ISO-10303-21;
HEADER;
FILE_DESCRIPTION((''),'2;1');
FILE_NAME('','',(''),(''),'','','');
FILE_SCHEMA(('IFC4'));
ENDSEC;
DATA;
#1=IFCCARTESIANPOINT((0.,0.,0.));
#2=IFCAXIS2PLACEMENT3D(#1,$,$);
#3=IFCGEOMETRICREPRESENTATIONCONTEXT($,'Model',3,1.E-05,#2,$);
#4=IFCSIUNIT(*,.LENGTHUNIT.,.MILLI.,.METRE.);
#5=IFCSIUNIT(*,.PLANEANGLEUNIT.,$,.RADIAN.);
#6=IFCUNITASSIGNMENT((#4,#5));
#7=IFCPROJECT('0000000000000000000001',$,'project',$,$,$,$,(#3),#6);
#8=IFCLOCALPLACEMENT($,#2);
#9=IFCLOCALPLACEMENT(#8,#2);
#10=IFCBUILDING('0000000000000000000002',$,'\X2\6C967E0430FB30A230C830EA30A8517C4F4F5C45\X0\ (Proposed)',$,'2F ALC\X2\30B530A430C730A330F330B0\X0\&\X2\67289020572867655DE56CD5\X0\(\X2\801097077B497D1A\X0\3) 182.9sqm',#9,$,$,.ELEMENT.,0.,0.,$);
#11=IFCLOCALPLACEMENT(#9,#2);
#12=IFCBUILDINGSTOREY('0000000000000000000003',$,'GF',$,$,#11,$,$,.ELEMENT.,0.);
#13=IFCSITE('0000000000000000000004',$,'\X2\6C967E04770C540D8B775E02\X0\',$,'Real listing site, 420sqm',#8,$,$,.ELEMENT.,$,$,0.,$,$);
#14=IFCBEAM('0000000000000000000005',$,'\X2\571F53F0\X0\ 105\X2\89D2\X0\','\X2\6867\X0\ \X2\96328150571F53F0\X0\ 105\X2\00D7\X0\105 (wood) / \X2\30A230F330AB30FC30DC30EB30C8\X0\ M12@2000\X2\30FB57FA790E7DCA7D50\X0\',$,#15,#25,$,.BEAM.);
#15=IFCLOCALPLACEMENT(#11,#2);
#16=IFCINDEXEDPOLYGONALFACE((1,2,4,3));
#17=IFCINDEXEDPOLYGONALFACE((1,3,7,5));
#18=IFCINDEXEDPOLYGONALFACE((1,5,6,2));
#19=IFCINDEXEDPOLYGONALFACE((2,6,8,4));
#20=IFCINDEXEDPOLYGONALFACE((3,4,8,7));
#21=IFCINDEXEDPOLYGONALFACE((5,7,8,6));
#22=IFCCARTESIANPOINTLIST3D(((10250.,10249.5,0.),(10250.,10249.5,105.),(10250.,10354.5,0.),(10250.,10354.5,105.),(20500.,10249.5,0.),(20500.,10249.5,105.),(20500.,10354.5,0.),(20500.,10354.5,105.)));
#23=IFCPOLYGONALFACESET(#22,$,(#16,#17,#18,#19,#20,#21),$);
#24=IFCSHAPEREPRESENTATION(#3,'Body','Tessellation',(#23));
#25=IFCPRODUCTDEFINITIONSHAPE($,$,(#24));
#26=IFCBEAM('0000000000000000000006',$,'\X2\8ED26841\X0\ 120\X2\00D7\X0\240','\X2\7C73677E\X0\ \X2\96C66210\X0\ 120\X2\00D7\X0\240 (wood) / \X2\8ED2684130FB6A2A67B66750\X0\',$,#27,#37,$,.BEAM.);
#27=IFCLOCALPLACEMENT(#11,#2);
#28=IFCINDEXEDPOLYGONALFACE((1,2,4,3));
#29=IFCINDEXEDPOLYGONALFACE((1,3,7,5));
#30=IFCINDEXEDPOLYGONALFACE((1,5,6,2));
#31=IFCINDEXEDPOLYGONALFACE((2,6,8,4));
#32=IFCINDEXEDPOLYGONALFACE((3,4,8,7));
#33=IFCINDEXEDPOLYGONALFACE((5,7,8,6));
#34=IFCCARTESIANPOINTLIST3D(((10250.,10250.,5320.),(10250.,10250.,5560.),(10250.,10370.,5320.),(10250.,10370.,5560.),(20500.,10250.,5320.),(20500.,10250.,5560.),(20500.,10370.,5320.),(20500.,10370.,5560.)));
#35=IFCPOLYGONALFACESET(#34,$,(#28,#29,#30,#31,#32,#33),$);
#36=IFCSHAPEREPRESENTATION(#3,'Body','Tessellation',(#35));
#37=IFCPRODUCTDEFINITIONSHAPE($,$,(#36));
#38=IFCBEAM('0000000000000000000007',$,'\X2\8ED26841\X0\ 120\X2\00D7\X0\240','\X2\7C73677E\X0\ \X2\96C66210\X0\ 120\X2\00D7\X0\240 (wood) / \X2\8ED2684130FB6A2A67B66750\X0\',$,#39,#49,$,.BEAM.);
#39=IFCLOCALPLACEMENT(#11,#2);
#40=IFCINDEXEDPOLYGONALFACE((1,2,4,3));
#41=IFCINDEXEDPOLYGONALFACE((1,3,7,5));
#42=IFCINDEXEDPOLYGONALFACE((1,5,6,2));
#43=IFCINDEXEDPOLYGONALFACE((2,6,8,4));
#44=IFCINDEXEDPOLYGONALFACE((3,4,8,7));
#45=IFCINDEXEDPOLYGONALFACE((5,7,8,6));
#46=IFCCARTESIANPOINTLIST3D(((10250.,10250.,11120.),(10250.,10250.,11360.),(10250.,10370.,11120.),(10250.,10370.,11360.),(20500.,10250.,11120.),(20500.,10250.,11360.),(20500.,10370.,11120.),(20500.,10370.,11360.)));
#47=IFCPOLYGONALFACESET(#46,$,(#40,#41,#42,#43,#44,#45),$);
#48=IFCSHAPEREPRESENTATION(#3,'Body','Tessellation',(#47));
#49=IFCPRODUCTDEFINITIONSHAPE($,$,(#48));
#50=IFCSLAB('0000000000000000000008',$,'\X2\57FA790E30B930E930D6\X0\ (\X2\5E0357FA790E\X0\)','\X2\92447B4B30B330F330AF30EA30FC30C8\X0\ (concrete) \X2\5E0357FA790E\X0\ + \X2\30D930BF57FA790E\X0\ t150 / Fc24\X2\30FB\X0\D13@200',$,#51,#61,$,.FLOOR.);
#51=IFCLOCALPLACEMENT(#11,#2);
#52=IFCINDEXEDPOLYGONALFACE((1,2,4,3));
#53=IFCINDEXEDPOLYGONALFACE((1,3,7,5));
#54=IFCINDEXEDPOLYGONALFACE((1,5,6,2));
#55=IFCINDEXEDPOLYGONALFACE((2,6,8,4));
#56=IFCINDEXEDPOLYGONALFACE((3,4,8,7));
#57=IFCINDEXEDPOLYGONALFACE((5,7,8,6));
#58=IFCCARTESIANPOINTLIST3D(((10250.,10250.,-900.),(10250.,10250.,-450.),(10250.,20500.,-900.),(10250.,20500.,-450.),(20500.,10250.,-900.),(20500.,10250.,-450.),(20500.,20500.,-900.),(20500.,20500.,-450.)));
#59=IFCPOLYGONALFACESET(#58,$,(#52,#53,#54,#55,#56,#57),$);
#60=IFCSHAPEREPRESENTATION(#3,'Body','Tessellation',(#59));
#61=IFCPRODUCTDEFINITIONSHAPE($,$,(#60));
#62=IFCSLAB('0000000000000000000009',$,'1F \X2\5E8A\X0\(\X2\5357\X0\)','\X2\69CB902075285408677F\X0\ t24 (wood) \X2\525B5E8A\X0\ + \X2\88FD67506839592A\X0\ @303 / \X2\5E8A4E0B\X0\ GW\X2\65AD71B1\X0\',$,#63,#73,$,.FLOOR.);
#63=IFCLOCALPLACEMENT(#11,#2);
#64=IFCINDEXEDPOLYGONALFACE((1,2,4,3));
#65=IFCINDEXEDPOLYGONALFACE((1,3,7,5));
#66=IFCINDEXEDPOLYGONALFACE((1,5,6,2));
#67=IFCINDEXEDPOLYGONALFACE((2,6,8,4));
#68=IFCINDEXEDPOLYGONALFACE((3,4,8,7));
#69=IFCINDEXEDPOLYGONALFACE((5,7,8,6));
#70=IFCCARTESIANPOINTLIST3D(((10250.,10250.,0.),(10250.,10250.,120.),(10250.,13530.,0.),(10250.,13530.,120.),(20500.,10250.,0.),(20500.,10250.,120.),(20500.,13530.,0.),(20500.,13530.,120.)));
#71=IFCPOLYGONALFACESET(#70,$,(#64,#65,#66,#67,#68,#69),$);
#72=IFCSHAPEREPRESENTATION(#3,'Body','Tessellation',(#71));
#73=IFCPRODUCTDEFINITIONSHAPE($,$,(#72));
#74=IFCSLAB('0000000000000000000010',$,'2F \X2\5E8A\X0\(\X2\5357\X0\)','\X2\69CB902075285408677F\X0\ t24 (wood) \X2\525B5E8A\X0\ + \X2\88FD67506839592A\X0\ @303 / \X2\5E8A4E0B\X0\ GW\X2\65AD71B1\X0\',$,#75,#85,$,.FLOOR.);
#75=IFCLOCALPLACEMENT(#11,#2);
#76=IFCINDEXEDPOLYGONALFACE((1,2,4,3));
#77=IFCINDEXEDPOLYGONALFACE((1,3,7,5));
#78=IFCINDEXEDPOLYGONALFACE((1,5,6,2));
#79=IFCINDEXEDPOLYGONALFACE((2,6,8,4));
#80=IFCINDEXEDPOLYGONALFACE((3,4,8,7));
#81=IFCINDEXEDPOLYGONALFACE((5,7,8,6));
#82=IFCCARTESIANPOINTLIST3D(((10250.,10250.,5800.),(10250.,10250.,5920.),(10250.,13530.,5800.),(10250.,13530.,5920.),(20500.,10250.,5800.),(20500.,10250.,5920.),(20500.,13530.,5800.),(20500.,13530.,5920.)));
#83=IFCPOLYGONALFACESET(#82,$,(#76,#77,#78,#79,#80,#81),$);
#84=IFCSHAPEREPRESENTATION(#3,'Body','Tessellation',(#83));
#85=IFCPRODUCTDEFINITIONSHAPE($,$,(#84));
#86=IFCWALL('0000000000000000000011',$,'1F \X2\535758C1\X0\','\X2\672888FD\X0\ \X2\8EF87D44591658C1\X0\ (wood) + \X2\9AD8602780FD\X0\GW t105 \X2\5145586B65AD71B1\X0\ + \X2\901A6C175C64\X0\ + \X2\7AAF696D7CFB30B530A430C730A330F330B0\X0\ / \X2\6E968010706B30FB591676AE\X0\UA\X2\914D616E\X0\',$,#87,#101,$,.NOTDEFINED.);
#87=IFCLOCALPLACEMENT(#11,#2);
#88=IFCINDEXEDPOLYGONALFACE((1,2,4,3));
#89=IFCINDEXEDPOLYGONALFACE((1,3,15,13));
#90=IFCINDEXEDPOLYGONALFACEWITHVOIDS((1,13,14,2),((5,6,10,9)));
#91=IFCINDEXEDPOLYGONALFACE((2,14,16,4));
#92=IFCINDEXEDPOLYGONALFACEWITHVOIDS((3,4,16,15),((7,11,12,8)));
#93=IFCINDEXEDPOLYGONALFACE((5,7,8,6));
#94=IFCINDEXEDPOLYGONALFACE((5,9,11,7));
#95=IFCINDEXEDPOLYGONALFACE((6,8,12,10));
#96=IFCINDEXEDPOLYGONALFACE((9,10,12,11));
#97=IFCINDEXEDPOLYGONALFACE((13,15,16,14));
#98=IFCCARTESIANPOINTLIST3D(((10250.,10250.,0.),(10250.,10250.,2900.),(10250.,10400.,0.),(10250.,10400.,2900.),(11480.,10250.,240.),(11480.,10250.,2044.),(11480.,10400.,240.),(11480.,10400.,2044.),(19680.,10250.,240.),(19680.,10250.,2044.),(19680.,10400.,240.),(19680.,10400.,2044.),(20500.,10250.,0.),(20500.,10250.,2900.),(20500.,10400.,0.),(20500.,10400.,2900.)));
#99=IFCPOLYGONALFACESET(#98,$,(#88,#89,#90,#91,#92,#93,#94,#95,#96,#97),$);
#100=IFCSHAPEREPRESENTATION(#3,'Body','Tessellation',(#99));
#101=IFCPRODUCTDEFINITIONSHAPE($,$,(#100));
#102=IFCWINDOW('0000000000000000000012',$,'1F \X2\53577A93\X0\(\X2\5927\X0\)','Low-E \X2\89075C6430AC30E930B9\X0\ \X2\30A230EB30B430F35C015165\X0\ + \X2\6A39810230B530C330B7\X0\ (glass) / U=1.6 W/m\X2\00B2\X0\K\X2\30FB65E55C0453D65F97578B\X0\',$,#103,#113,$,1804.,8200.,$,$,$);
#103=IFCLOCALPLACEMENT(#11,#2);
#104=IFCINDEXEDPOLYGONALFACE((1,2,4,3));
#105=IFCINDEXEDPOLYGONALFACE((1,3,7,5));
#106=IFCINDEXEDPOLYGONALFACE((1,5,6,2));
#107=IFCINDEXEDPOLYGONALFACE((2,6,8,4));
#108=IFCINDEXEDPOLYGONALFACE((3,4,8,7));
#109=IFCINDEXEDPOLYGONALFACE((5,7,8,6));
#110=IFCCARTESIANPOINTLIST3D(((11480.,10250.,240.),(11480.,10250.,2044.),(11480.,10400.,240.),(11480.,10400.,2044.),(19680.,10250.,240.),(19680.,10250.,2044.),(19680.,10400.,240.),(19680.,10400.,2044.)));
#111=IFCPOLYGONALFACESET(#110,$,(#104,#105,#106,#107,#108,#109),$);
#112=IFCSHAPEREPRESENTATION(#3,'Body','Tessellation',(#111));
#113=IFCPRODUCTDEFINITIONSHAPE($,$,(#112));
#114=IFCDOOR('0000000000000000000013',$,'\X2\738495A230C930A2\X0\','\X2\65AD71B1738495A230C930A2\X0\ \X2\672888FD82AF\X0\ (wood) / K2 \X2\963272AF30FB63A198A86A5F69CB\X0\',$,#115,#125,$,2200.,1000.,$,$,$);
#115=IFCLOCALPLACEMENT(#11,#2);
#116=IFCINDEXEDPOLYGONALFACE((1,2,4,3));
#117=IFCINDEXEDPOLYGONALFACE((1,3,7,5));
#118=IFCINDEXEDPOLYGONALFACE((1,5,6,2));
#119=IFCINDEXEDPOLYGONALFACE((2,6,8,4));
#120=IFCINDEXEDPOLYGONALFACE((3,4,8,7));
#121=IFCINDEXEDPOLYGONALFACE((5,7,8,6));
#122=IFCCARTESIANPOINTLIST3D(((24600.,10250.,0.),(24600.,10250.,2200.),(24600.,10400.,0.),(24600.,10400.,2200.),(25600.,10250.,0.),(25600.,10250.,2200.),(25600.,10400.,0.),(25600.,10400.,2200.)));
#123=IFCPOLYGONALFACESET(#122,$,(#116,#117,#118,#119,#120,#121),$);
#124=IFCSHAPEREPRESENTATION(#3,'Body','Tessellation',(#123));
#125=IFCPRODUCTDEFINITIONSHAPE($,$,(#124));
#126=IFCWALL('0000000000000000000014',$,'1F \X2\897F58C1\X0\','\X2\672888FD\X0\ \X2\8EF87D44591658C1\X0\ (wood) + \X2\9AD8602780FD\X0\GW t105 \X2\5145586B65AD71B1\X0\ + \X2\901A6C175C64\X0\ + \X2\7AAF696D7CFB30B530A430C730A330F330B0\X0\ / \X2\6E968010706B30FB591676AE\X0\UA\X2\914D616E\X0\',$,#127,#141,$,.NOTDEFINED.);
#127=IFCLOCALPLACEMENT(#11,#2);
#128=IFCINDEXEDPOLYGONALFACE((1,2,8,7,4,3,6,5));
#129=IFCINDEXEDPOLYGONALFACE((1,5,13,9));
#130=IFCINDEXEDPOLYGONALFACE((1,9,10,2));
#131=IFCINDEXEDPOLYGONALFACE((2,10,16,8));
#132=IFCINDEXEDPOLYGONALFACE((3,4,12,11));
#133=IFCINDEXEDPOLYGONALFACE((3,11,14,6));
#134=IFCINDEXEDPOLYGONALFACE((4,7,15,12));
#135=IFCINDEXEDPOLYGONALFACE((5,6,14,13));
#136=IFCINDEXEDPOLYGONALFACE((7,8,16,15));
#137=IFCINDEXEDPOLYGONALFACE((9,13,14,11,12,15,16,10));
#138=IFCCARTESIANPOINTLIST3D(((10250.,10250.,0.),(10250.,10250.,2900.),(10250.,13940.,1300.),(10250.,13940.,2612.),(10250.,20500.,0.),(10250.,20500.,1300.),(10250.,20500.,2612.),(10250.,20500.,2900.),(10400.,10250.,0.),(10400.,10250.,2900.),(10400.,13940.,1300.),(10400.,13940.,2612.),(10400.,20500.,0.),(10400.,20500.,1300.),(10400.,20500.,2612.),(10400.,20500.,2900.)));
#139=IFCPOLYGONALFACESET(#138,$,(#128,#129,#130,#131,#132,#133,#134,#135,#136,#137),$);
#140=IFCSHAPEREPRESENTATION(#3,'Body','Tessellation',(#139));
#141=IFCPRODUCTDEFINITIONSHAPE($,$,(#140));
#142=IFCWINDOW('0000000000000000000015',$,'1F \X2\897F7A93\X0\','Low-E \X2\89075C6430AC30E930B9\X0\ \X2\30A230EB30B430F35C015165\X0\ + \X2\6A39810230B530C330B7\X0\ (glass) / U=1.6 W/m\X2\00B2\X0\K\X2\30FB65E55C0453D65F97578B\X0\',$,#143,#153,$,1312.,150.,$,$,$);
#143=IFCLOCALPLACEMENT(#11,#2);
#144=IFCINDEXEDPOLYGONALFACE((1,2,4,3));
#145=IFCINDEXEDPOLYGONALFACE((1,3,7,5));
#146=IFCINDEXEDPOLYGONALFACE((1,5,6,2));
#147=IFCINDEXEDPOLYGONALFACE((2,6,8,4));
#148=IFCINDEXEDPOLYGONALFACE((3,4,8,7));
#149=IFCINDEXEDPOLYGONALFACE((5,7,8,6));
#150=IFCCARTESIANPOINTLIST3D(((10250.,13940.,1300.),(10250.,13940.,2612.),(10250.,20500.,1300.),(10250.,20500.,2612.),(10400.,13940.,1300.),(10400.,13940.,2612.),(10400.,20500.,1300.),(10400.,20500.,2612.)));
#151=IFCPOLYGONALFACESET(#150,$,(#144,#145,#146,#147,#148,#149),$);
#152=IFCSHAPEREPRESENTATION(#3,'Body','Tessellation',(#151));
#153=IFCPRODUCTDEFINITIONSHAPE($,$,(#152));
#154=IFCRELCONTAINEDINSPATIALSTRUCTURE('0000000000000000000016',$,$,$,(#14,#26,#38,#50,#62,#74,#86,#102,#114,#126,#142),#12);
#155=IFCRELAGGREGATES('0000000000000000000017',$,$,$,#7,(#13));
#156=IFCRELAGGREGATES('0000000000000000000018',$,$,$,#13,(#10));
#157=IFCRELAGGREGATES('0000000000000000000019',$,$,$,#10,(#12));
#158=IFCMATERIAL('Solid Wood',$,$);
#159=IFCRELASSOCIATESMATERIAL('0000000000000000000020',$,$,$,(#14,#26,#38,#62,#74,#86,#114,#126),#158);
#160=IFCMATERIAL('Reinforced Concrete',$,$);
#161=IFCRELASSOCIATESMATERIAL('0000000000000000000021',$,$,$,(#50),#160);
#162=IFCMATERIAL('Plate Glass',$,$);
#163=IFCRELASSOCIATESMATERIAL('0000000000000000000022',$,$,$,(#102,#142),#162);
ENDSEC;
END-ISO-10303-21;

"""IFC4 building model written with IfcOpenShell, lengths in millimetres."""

from ifc_helpers import new_model, si_unit, frame, frame_2d, origin, place, context, project, spatial, rectangle, extrude, material, element, fill, save


model = new_model("IFC4")

# Units and contexts
model_context = context("Model", 3, precision=1e-05, world=origin())
ifc_project = project(units=[si_unit("LENGTHUNIT", "METRE", prefix="MILLI"), si_unit("PLANEANGLEUNIT", "RADIAN")], contexts=[model_context])

# Site, building, storey
site_placement = place(None, origin())
site = spatial("IfcSite", under=ifc_project, at=site_placement, Name="沖縄県名護市", ObjectType="Real listing site, 420sqm", CompositionType="ELEMENT", RefElevation=0.0)
building_placement = place(site_placement, origin())
building = spatial("IfcBuilding", under=site, at=building_placement, Name="沖縄・アトリエ兼住居 (Proposed)", ObjectType="2F ALCサイディング&木造在来工法(耐震等級3) 182.9sqm", CompositionType="ELEMENT", ElevationOfRefHeight=0.0, ElevationOfTerrain=0.0)
storey_placement = place(building_placement, origin())
storey = spatial("IfcBuildingStorey", under=building, at=storey_placement, Name="GF", CompositionType="ELEMENT", Elevation=0.0)

# Shared definitions
ifc_material_1 = material(Name="Solid Wood")

# Beams
beam_1_placement = place(storey_placement, frame((5125.0, 5125.0, 0.0)))
element("IfcBeam", 1, at=beam_1_placement, inside=storey, material=ifc_material_1, Name="土台 105角", Description="桧 防腐土台 105×105 (wood) / アンカーボルト M12@2000・基礎緊結", PredefinedType="BEAM", context=model_context, shape_type="SweptSolid", body=[
    extrude(rectangle(XDim=10250.0, YDim=105.0, at=frame_2d((5125.0, 52.0))), frame((5125.0, 5125.0, 0.0)), (0.0, 0.0, 1.0), 105.0),
])
beam_2_placement = place(storey_placement, frame((5125.0, 5125.0, 2660.0)))
element("IfcBeam", 2, at=beam_2_placement, inside=storey, material=ifc_material_1, Name="軒桁 120×240", Description="米松 集成 120×240 (wood) / 軒桁・横架材", PredefinedType="BEAM", context=model_context, shape_type="SweptSolid", body=[
    extrude(rectangle(XDim=10250.0, YDim=120.0, at=frame_2d((5125.0, 60.0))), frame((5125.0, 5125.0, 2660.0)), (0.0, 0.0, 1.0), 240.0),
])
beam_3_placement = place(storey_placement, frame((5125.0, 5125.0, 5560.0)))
element("IfcBeam", 3, at=beam_3_placement, inside=storey, material=ifc_material_1, Name="軒桁 120×240", Description="米松 集成 120×240 (wood) / 軒桁・横架材", PredefinedType="BEAM", context=model_context, shape_type="SweptSolid", body=[
    extrude(rectangle(XDim=10250.0, YDim=120.0, at=frame_2d((5125.0, 60.0))), frame((5125.0, 5125.0, 5560.0)), (0.0, 0.0, 1.0), 240.0),
])

# Slabs
ifc_material_2 = material(Name="Reinforced Concrete")
slab_1_placement = place(storey_placement, frame((5125.0, 5125.0, -450.0)))
element("IfcSlab", 4, at=slab_1_placement, inside=storey, material=ifc_material_2, Name="基礎スラブ (布基礎)", Description="鉄筋コンクリート (concrete) 布基礎 + ベタ基礎 t150 / Fc24・D13@200", PredefinedType="FLOOR", context=model_context, shape_type="SweptSolid", body=[
    extrude(rectangle(XDim=10250.0, YDim=10250.0, at=frame_2d((5125.0, 5125.0))), frame((5125.0, 5125.0, -450.0)), (0.0, 0.0, 1.0), 450.0),
])
slab_2_placement = place(storey_placement, frame((5125.0, 5125.0, 0.0)))
element("IfcSlab", 5, at=slab_2_placement, inside=storey, material=ifc_material_1, Name="1F 床(南)", Description="構造用合板 t24 (wood) 剛床 + 製材根太 @303 / 床下 GW断熱", PredefinedType="FLOOR", context=model_context, shape_type="SweptSolid", body=[
    extrude(rectangle(XDim=10250.0, YDim=3280.0, at=frame_2d((5125.0, 1640.0))), frame((5125.0, 5125.0, 0.0)), (0.0, 0.0, 1.0), 120.0),
])
slab_3_placement = place(storey_placement, frame((5125.0, 5125.0, 2900.0)))
element("IfcSlab", 6, at=slab_3_placement, inside=storey, material=ifc_material_1, Name="2F 床(南)", Description="構造用合板 t24 (wood) 剛床 + 製材根太 @303 / 床下 GW断熱", PredefinedType="FLOOR", context=model_context, shape_type="SweptSolid", body=[
    extrude(rectangle(XDim=10250.0, YDim=3280.0, at=frame_2d((5125.0, 1640.0))), frame((5125.0, 5125.0, 2900.0)), (0.0, 0.0, 1.0), 120.0),
])

# Wall, openings, window, door
wall_1_placement = place(storey_placement, frame((5125.0, 5125.0, 0.0)))
wall_1 = element("IfcWall", 7, at=wall_1_placement, inside=storey, material=ifc_material_1, Name="1F 南壁", Description="木製 軸組外壁 (wood) + 高性能GW t105 充填断熱 + 通気層 + 窯業系サイディング / 準耐火・外皮UA配慮", PredefinedType="NOTDEFINED", context=model_context, shape_type="SweptSolid", body=[
    extrude(rectangle(XDim=10250.0, YDim=150.0, at=frame_2d((5125.0, 75.0))), frame((5125.0, 5125.0, 0.0)), (0.0, 0.0, 1.0), 2900.0),
])
opening_1_placement = place(storey_placement, frame((5740.0, 5125.0, 120.0)))
opening_1 = element("IfcOpeningElement", 8, at=opening_1_placement, cuts=wall_1, PredefinedType="NOTDEFINED", context=model_context, shape_type="SweptSolid", body=[
    extrude(rectangle(XDim=8200.0, YDim=150.0, at=frame_2d((4100.0, 75.0))), frame((5740.0, 5125.0, 120.0)), (0.0, 0.0, 1.0), 1804.0),
])
opening_2_placement = place(storey_placement, frame((12300.0, 5125.0, 0.0)))
opening_2 = element("IfcOpeningElement", 9, at=opening_2_placement, cuts=wall_1, PredefinedType="NOTDEFINED", context=model_context, shape_type="SweptSolid", body=[
    extrude(rectangle(XDim=1000.0, YDim=150.0, at=frame_2d((500.0, 75.0))), frame((12300.0, 5125.0, 0.0)), (0.0, 0.0, 1.0), 2200.0),
])
ifc_material_3 = material(Name="Plate Glass")
window_1_placement = place(storey_placement, frame((5740.0, 5125.0, 120.0)))
window_1 = element("IfcWindow", 10, at=window_1_placement, inside=storey, material=ifc_material_3, Name="1F 南窓(大)", Description="Low-E 複層ガラス アルゴン封入 + 樹脂サッシ (glass) / U=1.6 W/m²K・日射取得型", OverallHeight=1804.0, OverallWidth=8200.0, context=model_context, shape_type="SweptSolid", body=[
    extrude(rectangle(XDim=8200.0, YDim=150.0, at=frame_2d((4100.0, 75.0))), frame((5740.0, 5125.0, 120.0)), (0.0, 0.0, 1.0), 1804.0),
])
fill(opening_1, window_1)
door_placement = place(storey_placement, frame((12300.0, 5125.0, 0.0)))
door = element("IfcDoor", 11, at=door_placement, inside=storey, material=ifc_material_1, Name="玄関ドア", Description="断熱玄関ドア 木製芯 (wood) / K2 防犯・採風機構", OverallHeight=2200.0, OverallWidth=1000.0, context=model_context, shape_type="SweptSolid", body=[
    extrude(rectangle(XDim=1000.0, YDim=150.0, at=frame_2d((500.0, 75.0))), frame((12300.0, 5125.0, 0.0)), (0.0, 0.0, 1.0), 2200.0),
])
fill(opening_2, door)

# Wall, opening, window
wall_2_placement = place(storey_placement, frame((5125.0, 5125.0, 0.0)))
wall_2 = element("IfcWall", 12, at=wall_2_placement, inside=storey, material=ifc_material_1, Name="1F 西壁", Description="木製 軸組外壁 (wood) + 高性能GW t105 充填断熱 + 通気層 + 窯業系サイディング / 準耐火・外皮UA配慮", PredefinedType="NOTDEFINED", context=model_context, shape_type="SweptSolid", body=[
    extrude(rectangle(XDim=150.0, YDim=10250.0, at=frame_2d((75.0, 5125.0))), frame((5125.0, 5125.0, 0.0)), (0.0, 0.0, 1.0), 2900.0),
])
opening_3_placement = place(storey_placement, frame((5125.0, 6970.0, 650.0)))
opening_3 = element("IfcOpeningElement", 13, at=opening_3_placement, cuts=wall_2, PredefinedType="NOTDEFINED", context=model_context, shape_type="SweptSolid", body=[
    extrude(rectangle(XDim=150.0, YDim=6560.0, at=frame_2d((75.0, 3280.0))), frame((5125.0, 6970.0, 650.0)), (0.0, 0.0, 1.0), 1312.0),
])
window_2_placement = place(storey_placement, frame((5125.0, 6970.0, 650.0)))
window_2 = element("IfcWindow", 14, at=window_2_placement, inside=storey, material=ifc_material_3, Name="1F 西窓", Description="Low-E 複層ガラス アルゴン封入 + 樹脂サッシ (glass) / U=1.6 W/m²K・日射取得型", OverallHeight=1312.0, OverallWidth=150.0, context=model_context, shape_type="SweptSolid", body=[
    extrude(rectangle(XDim=150.0, YDim=6560.0, at=frame_2d((75.0, 3280.0))), frame((5125.0, 6970.0, 650.0)), (0.0, 0.0, 1.0), 1312.0),
])
fill(opening_3, window_2)

save(model, "model.ifc")
